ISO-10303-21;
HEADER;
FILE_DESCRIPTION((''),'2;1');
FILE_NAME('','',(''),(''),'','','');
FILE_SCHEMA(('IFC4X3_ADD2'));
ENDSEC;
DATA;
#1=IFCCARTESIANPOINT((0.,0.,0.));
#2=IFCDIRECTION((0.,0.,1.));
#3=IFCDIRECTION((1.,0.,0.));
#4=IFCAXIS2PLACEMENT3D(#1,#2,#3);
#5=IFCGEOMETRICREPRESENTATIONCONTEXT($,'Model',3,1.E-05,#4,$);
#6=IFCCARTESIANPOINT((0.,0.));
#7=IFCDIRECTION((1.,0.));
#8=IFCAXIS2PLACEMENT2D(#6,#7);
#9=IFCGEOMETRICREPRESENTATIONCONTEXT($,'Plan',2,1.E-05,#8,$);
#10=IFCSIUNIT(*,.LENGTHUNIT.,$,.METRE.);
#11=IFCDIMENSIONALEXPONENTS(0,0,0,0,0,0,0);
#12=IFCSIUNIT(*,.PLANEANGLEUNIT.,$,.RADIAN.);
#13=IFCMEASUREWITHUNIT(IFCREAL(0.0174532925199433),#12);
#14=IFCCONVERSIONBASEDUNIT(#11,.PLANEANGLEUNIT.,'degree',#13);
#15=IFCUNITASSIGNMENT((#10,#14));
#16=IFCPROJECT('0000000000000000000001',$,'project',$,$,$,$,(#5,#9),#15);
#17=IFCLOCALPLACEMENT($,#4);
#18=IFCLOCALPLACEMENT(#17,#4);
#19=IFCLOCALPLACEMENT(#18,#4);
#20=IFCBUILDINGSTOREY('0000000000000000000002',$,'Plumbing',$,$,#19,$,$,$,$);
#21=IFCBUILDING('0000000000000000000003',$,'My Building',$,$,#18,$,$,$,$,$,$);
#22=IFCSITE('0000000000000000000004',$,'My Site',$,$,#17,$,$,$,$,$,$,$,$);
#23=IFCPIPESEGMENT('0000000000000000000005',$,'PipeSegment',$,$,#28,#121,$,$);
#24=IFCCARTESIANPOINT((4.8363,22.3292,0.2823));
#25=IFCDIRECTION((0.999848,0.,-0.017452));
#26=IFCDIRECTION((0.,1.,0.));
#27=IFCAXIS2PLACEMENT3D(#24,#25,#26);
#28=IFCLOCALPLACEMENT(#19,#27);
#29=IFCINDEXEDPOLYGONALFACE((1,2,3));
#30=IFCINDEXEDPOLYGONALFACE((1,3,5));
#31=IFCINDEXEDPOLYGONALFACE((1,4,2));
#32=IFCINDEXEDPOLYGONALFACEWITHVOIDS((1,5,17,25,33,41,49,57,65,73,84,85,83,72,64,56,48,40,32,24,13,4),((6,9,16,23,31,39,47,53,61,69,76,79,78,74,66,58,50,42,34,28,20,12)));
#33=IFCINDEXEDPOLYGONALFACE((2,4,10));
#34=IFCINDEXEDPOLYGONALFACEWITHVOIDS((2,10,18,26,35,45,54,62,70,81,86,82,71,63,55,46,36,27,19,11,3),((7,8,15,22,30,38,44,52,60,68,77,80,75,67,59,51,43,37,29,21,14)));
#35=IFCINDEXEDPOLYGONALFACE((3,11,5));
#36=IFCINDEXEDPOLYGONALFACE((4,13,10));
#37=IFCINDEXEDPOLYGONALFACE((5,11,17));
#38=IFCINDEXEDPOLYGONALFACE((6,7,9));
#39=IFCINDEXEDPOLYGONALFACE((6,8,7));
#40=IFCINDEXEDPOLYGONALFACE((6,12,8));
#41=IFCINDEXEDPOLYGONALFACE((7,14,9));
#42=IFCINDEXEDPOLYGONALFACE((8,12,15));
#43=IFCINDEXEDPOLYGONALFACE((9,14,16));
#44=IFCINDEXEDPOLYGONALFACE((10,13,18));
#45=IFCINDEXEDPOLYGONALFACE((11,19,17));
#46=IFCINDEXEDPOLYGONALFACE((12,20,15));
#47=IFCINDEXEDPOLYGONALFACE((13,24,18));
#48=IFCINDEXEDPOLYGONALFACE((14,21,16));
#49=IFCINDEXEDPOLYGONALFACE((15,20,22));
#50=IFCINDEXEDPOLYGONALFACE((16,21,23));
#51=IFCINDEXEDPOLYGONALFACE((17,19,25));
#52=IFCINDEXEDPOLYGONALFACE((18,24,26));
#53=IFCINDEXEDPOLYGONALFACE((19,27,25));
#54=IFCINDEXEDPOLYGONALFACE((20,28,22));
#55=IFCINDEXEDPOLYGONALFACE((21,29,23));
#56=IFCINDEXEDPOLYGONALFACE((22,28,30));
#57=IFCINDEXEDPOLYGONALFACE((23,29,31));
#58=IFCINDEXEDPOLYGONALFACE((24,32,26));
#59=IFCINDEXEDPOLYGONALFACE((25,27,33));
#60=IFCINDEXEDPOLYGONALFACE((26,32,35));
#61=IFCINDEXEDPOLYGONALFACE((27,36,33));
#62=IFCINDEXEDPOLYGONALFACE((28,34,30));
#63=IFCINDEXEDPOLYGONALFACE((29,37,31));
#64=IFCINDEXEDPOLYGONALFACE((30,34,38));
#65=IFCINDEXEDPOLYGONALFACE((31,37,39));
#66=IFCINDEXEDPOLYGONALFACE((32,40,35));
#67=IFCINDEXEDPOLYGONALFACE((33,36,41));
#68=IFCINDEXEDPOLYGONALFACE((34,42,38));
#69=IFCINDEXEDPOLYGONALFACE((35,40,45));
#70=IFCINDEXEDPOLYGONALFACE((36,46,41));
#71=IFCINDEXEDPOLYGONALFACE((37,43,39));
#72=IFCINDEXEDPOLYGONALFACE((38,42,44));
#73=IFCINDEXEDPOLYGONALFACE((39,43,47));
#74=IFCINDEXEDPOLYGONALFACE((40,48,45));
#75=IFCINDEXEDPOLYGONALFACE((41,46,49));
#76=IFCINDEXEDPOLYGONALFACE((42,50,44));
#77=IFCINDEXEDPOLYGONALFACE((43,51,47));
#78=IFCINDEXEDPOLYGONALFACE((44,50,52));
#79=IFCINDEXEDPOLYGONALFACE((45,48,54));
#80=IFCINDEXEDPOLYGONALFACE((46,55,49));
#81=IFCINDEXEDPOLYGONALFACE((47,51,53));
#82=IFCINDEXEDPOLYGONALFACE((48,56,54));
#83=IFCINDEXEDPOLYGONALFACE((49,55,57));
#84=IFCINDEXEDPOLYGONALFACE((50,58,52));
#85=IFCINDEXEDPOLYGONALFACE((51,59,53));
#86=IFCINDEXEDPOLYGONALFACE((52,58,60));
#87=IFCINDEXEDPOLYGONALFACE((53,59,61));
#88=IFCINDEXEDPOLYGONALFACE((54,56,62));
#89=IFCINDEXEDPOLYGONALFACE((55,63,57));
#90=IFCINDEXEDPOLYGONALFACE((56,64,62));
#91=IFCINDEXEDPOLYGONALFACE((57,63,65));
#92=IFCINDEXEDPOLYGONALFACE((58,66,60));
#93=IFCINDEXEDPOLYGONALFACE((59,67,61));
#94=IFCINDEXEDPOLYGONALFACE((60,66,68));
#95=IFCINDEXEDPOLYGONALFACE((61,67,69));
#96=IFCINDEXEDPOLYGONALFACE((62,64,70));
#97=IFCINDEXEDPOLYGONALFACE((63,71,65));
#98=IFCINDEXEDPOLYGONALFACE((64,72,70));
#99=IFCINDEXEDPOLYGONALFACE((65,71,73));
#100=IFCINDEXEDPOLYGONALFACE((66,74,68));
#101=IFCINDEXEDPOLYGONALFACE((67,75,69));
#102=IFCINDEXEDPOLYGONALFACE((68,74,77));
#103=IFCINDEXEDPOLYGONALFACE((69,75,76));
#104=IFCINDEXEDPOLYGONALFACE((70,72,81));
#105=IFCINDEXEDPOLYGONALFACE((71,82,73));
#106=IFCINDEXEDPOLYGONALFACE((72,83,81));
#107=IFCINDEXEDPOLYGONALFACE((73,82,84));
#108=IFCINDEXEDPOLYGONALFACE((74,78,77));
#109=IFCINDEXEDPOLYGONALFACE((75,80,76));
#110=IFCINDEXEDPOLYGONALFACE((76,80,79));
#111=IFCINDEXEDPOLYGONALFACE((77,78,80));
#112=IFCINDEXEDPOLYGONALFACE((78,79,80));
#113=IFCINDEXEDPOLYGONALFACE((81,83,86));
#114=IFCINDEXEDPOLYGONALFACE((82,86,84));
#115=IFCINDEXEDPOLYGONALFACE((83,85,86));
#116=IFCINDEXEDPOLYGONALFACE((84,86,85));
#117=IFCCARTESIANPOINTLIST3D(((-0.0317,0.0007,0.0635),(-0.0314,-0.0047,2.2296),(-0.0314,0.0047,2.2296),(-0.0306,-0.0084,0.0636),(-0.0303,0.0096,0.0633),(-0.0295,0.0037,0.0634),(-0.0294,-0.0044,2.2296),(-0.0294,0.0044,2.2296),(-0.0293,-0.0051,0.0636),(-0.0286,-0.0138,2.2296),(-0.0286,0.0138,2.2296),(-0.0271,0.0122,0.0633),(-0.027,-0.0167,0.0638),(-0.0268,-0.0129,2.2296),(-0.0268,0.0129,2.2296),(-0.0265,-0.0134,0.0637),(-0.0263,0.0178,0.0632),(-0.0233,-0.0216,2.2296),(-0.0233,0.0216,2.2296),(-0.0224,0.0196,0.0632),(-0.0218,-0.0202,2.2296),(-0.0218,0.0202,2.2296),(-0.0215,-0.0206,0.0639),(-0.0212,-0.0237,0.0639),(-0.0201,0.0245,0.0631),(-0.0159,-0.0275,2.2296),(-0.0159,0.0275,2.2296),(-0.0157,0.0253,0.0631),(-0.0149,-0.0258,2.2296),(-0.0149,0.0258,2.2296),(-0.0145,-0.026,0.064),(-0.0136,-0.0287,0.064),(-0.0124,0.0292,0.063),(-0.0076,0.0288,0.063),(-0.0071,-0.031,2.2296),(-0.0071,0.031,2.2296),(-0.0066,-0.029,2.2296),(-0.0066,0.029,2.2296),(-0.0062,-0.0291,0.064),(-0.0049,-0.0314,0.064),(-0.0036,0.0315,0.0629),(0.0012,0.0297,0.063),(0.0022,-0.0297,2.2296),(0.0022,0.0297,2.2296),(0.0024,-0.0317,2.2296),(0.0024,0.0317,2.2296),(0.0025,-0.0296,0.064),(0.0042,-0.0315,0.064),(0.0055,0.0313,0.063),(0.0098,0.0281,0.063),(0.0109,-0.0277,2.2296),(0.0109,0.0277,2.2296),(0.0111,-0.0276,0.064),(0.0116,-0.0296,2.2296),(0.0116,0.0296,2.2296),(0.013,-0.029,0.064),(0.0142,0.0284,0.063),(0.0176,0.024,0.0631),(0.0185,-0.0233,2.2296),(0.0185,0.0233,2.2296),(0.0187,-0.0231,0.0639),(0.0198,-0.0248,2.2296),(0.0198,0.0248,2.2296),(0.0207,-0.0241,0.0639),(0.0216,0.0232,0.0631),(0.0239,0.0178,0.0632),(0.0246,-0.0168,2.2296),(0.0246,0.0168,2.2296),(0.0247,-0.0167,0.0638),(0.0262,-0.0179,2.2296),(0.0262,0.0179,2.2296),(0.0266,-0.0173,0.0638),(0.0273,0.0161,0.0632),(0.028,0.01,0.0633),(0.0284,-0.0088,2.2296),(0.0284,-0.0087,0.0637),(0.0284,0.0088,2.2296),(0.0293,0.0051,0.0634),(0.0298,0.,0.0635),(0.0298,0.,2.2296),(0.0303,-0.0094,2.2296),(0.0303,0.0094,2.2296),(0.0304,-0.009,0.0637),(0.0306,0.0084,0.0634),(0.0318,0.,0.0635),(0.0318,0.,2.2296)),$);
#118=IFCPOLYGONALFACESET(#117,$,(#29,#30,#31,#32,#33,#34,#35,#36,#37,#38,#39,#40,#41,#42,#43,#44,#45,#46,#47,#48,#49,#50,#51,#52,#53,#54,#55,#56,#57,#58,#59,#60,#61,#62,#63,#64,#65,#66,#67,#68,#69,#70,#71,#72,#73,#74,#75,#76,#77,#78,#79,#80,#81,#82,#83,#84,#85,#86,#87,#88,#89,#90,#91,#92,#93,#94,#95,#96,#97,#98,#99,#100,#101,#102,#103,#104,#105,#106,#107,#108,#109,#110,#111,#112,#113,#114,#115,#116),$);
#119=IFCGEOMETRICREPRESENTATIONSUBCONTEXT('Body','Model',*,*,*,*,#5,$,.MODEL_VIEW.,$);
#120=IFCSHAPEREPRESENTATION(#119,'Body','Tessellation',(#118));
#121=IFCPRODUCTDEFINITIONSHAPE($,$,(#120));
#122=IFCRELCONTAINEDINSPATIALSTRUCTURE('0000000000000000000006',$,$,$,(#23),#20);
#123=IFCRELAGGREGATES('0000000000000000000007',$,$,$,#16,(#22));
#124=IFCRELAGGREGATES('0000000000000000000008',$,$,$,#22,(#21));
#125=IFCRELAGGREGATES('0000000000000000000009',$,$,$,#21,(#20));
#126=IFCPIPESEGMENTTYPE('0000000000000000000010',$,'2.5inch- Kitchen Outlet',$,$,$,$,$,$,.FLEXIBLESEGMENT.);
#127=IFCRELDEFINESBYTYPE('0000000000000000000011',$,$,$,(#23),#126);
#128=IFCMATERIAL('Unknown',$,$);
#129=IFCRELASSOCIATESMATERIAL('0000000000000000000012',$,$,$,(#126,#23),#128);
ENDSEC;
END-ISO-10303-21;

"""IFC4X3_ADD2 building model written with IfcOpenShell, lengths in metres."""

from ifc_helpers import new_model, entity, si_unit, converted_unit, frame, origin_with_axes, origin_2d_with_axis, place, context, subcontext, project, spatial, hollow_circle, extrude, clip, halfspace, material, material_profile, profile_set, profile_usage, type_object, element, save


model = new_model("IFC4X3_ADD2")

# Units and contexts
model_context = context("Model", 3, precision=1e-05, world=origin_with_axes())
plan_context = context("Plan", 2, precision=1e-05, world=origin_2d_with_axis())
body_context = subcontext(model_context, "Body", "Model", "MODEL_VIEW")
ifc_project = project(units=[si_unit("LENGTHUNIT", "METRE"), converted_unit("PLANEANGLEUNIT", "degree", entity("IfcReal", 0.0174532925199433), si_unit("PLANEANGLEUNIT", "RADIAN"), dimensions=[0, 0, 0, 0, 0, 0, 0])], contexts=[model_context, plan_context])

# Site, building, storey
site_placement = place(None, origin_with_axes())
site = spatial("IfcSite", under=ifc_project, at=site_placement, Name="My Site")
building_placement = place(site_placement, origin_with_axes())
building = spatial("IfcBuilding", under=site, at=building_placement, Name="My Building")
storey_placement = place(building_placement, origin_with_axes())
storey = spatial("IfcBuildingStorey", under=building, at=storey_placement, Name="Plumbing")

# Pipe segment
ifc_material_1 = material(Name="Unknown")
ifc_material_profile_1 = material_profile(ifc_material_1, hollow_circle(Radius=0.0318, WallThickness=0.002))
ifc_profile_set_1 = profile_set([ifc_material_profile_1], Name="kitchenwater")
ifc_profile_usage_1 = profile_usage(ifc_profile_set_1)
ifc_material_profile_2 = material_profile(ifc_material_1, hollow_circle(Radius=0.0318, WallThickness=0.002))
ifc_profile_set_2 = profile_set([ifc_material_profile_2], Name="kitchenwater")
pipe_segment_type_1 = type_object("IfcPipeSegmentType", Name="2.5inch- Kitchen Outlet", PredefinedType="FLEXIBLESEGMENT", material=ifc_profile_set_2)
pipe_segment_1_placement = place(storey_placement, frame((4.8363, 22.3292, 0.2823), z_axis=(0.999848, 0.0, -0.017452), x_axis=(0.0, 1.0, 0.0)))
element("IfcPipeSegment", 1, at=pipe_segment_1_placement, inside=storey, type_object=pipe_segment_type_1, material=ifc_profile_usage_1, Name="PipeSegment", context=body_context, shape_type="Clipping", body=[
    clip(extrude(hollow_circle(Radius=0.0318, WallThickness=0.002), origin_with_axes(), (0.0, 0.0, 1.0), 2.2296), halfspace(frame((3.5471, 0.0213, 0.0631), z_axis=(0.0, -0.017452, -0.999848), x_axis=(-1.0, -0.000003, 0.0)), False)),
])

save(model, "model.ifc")
